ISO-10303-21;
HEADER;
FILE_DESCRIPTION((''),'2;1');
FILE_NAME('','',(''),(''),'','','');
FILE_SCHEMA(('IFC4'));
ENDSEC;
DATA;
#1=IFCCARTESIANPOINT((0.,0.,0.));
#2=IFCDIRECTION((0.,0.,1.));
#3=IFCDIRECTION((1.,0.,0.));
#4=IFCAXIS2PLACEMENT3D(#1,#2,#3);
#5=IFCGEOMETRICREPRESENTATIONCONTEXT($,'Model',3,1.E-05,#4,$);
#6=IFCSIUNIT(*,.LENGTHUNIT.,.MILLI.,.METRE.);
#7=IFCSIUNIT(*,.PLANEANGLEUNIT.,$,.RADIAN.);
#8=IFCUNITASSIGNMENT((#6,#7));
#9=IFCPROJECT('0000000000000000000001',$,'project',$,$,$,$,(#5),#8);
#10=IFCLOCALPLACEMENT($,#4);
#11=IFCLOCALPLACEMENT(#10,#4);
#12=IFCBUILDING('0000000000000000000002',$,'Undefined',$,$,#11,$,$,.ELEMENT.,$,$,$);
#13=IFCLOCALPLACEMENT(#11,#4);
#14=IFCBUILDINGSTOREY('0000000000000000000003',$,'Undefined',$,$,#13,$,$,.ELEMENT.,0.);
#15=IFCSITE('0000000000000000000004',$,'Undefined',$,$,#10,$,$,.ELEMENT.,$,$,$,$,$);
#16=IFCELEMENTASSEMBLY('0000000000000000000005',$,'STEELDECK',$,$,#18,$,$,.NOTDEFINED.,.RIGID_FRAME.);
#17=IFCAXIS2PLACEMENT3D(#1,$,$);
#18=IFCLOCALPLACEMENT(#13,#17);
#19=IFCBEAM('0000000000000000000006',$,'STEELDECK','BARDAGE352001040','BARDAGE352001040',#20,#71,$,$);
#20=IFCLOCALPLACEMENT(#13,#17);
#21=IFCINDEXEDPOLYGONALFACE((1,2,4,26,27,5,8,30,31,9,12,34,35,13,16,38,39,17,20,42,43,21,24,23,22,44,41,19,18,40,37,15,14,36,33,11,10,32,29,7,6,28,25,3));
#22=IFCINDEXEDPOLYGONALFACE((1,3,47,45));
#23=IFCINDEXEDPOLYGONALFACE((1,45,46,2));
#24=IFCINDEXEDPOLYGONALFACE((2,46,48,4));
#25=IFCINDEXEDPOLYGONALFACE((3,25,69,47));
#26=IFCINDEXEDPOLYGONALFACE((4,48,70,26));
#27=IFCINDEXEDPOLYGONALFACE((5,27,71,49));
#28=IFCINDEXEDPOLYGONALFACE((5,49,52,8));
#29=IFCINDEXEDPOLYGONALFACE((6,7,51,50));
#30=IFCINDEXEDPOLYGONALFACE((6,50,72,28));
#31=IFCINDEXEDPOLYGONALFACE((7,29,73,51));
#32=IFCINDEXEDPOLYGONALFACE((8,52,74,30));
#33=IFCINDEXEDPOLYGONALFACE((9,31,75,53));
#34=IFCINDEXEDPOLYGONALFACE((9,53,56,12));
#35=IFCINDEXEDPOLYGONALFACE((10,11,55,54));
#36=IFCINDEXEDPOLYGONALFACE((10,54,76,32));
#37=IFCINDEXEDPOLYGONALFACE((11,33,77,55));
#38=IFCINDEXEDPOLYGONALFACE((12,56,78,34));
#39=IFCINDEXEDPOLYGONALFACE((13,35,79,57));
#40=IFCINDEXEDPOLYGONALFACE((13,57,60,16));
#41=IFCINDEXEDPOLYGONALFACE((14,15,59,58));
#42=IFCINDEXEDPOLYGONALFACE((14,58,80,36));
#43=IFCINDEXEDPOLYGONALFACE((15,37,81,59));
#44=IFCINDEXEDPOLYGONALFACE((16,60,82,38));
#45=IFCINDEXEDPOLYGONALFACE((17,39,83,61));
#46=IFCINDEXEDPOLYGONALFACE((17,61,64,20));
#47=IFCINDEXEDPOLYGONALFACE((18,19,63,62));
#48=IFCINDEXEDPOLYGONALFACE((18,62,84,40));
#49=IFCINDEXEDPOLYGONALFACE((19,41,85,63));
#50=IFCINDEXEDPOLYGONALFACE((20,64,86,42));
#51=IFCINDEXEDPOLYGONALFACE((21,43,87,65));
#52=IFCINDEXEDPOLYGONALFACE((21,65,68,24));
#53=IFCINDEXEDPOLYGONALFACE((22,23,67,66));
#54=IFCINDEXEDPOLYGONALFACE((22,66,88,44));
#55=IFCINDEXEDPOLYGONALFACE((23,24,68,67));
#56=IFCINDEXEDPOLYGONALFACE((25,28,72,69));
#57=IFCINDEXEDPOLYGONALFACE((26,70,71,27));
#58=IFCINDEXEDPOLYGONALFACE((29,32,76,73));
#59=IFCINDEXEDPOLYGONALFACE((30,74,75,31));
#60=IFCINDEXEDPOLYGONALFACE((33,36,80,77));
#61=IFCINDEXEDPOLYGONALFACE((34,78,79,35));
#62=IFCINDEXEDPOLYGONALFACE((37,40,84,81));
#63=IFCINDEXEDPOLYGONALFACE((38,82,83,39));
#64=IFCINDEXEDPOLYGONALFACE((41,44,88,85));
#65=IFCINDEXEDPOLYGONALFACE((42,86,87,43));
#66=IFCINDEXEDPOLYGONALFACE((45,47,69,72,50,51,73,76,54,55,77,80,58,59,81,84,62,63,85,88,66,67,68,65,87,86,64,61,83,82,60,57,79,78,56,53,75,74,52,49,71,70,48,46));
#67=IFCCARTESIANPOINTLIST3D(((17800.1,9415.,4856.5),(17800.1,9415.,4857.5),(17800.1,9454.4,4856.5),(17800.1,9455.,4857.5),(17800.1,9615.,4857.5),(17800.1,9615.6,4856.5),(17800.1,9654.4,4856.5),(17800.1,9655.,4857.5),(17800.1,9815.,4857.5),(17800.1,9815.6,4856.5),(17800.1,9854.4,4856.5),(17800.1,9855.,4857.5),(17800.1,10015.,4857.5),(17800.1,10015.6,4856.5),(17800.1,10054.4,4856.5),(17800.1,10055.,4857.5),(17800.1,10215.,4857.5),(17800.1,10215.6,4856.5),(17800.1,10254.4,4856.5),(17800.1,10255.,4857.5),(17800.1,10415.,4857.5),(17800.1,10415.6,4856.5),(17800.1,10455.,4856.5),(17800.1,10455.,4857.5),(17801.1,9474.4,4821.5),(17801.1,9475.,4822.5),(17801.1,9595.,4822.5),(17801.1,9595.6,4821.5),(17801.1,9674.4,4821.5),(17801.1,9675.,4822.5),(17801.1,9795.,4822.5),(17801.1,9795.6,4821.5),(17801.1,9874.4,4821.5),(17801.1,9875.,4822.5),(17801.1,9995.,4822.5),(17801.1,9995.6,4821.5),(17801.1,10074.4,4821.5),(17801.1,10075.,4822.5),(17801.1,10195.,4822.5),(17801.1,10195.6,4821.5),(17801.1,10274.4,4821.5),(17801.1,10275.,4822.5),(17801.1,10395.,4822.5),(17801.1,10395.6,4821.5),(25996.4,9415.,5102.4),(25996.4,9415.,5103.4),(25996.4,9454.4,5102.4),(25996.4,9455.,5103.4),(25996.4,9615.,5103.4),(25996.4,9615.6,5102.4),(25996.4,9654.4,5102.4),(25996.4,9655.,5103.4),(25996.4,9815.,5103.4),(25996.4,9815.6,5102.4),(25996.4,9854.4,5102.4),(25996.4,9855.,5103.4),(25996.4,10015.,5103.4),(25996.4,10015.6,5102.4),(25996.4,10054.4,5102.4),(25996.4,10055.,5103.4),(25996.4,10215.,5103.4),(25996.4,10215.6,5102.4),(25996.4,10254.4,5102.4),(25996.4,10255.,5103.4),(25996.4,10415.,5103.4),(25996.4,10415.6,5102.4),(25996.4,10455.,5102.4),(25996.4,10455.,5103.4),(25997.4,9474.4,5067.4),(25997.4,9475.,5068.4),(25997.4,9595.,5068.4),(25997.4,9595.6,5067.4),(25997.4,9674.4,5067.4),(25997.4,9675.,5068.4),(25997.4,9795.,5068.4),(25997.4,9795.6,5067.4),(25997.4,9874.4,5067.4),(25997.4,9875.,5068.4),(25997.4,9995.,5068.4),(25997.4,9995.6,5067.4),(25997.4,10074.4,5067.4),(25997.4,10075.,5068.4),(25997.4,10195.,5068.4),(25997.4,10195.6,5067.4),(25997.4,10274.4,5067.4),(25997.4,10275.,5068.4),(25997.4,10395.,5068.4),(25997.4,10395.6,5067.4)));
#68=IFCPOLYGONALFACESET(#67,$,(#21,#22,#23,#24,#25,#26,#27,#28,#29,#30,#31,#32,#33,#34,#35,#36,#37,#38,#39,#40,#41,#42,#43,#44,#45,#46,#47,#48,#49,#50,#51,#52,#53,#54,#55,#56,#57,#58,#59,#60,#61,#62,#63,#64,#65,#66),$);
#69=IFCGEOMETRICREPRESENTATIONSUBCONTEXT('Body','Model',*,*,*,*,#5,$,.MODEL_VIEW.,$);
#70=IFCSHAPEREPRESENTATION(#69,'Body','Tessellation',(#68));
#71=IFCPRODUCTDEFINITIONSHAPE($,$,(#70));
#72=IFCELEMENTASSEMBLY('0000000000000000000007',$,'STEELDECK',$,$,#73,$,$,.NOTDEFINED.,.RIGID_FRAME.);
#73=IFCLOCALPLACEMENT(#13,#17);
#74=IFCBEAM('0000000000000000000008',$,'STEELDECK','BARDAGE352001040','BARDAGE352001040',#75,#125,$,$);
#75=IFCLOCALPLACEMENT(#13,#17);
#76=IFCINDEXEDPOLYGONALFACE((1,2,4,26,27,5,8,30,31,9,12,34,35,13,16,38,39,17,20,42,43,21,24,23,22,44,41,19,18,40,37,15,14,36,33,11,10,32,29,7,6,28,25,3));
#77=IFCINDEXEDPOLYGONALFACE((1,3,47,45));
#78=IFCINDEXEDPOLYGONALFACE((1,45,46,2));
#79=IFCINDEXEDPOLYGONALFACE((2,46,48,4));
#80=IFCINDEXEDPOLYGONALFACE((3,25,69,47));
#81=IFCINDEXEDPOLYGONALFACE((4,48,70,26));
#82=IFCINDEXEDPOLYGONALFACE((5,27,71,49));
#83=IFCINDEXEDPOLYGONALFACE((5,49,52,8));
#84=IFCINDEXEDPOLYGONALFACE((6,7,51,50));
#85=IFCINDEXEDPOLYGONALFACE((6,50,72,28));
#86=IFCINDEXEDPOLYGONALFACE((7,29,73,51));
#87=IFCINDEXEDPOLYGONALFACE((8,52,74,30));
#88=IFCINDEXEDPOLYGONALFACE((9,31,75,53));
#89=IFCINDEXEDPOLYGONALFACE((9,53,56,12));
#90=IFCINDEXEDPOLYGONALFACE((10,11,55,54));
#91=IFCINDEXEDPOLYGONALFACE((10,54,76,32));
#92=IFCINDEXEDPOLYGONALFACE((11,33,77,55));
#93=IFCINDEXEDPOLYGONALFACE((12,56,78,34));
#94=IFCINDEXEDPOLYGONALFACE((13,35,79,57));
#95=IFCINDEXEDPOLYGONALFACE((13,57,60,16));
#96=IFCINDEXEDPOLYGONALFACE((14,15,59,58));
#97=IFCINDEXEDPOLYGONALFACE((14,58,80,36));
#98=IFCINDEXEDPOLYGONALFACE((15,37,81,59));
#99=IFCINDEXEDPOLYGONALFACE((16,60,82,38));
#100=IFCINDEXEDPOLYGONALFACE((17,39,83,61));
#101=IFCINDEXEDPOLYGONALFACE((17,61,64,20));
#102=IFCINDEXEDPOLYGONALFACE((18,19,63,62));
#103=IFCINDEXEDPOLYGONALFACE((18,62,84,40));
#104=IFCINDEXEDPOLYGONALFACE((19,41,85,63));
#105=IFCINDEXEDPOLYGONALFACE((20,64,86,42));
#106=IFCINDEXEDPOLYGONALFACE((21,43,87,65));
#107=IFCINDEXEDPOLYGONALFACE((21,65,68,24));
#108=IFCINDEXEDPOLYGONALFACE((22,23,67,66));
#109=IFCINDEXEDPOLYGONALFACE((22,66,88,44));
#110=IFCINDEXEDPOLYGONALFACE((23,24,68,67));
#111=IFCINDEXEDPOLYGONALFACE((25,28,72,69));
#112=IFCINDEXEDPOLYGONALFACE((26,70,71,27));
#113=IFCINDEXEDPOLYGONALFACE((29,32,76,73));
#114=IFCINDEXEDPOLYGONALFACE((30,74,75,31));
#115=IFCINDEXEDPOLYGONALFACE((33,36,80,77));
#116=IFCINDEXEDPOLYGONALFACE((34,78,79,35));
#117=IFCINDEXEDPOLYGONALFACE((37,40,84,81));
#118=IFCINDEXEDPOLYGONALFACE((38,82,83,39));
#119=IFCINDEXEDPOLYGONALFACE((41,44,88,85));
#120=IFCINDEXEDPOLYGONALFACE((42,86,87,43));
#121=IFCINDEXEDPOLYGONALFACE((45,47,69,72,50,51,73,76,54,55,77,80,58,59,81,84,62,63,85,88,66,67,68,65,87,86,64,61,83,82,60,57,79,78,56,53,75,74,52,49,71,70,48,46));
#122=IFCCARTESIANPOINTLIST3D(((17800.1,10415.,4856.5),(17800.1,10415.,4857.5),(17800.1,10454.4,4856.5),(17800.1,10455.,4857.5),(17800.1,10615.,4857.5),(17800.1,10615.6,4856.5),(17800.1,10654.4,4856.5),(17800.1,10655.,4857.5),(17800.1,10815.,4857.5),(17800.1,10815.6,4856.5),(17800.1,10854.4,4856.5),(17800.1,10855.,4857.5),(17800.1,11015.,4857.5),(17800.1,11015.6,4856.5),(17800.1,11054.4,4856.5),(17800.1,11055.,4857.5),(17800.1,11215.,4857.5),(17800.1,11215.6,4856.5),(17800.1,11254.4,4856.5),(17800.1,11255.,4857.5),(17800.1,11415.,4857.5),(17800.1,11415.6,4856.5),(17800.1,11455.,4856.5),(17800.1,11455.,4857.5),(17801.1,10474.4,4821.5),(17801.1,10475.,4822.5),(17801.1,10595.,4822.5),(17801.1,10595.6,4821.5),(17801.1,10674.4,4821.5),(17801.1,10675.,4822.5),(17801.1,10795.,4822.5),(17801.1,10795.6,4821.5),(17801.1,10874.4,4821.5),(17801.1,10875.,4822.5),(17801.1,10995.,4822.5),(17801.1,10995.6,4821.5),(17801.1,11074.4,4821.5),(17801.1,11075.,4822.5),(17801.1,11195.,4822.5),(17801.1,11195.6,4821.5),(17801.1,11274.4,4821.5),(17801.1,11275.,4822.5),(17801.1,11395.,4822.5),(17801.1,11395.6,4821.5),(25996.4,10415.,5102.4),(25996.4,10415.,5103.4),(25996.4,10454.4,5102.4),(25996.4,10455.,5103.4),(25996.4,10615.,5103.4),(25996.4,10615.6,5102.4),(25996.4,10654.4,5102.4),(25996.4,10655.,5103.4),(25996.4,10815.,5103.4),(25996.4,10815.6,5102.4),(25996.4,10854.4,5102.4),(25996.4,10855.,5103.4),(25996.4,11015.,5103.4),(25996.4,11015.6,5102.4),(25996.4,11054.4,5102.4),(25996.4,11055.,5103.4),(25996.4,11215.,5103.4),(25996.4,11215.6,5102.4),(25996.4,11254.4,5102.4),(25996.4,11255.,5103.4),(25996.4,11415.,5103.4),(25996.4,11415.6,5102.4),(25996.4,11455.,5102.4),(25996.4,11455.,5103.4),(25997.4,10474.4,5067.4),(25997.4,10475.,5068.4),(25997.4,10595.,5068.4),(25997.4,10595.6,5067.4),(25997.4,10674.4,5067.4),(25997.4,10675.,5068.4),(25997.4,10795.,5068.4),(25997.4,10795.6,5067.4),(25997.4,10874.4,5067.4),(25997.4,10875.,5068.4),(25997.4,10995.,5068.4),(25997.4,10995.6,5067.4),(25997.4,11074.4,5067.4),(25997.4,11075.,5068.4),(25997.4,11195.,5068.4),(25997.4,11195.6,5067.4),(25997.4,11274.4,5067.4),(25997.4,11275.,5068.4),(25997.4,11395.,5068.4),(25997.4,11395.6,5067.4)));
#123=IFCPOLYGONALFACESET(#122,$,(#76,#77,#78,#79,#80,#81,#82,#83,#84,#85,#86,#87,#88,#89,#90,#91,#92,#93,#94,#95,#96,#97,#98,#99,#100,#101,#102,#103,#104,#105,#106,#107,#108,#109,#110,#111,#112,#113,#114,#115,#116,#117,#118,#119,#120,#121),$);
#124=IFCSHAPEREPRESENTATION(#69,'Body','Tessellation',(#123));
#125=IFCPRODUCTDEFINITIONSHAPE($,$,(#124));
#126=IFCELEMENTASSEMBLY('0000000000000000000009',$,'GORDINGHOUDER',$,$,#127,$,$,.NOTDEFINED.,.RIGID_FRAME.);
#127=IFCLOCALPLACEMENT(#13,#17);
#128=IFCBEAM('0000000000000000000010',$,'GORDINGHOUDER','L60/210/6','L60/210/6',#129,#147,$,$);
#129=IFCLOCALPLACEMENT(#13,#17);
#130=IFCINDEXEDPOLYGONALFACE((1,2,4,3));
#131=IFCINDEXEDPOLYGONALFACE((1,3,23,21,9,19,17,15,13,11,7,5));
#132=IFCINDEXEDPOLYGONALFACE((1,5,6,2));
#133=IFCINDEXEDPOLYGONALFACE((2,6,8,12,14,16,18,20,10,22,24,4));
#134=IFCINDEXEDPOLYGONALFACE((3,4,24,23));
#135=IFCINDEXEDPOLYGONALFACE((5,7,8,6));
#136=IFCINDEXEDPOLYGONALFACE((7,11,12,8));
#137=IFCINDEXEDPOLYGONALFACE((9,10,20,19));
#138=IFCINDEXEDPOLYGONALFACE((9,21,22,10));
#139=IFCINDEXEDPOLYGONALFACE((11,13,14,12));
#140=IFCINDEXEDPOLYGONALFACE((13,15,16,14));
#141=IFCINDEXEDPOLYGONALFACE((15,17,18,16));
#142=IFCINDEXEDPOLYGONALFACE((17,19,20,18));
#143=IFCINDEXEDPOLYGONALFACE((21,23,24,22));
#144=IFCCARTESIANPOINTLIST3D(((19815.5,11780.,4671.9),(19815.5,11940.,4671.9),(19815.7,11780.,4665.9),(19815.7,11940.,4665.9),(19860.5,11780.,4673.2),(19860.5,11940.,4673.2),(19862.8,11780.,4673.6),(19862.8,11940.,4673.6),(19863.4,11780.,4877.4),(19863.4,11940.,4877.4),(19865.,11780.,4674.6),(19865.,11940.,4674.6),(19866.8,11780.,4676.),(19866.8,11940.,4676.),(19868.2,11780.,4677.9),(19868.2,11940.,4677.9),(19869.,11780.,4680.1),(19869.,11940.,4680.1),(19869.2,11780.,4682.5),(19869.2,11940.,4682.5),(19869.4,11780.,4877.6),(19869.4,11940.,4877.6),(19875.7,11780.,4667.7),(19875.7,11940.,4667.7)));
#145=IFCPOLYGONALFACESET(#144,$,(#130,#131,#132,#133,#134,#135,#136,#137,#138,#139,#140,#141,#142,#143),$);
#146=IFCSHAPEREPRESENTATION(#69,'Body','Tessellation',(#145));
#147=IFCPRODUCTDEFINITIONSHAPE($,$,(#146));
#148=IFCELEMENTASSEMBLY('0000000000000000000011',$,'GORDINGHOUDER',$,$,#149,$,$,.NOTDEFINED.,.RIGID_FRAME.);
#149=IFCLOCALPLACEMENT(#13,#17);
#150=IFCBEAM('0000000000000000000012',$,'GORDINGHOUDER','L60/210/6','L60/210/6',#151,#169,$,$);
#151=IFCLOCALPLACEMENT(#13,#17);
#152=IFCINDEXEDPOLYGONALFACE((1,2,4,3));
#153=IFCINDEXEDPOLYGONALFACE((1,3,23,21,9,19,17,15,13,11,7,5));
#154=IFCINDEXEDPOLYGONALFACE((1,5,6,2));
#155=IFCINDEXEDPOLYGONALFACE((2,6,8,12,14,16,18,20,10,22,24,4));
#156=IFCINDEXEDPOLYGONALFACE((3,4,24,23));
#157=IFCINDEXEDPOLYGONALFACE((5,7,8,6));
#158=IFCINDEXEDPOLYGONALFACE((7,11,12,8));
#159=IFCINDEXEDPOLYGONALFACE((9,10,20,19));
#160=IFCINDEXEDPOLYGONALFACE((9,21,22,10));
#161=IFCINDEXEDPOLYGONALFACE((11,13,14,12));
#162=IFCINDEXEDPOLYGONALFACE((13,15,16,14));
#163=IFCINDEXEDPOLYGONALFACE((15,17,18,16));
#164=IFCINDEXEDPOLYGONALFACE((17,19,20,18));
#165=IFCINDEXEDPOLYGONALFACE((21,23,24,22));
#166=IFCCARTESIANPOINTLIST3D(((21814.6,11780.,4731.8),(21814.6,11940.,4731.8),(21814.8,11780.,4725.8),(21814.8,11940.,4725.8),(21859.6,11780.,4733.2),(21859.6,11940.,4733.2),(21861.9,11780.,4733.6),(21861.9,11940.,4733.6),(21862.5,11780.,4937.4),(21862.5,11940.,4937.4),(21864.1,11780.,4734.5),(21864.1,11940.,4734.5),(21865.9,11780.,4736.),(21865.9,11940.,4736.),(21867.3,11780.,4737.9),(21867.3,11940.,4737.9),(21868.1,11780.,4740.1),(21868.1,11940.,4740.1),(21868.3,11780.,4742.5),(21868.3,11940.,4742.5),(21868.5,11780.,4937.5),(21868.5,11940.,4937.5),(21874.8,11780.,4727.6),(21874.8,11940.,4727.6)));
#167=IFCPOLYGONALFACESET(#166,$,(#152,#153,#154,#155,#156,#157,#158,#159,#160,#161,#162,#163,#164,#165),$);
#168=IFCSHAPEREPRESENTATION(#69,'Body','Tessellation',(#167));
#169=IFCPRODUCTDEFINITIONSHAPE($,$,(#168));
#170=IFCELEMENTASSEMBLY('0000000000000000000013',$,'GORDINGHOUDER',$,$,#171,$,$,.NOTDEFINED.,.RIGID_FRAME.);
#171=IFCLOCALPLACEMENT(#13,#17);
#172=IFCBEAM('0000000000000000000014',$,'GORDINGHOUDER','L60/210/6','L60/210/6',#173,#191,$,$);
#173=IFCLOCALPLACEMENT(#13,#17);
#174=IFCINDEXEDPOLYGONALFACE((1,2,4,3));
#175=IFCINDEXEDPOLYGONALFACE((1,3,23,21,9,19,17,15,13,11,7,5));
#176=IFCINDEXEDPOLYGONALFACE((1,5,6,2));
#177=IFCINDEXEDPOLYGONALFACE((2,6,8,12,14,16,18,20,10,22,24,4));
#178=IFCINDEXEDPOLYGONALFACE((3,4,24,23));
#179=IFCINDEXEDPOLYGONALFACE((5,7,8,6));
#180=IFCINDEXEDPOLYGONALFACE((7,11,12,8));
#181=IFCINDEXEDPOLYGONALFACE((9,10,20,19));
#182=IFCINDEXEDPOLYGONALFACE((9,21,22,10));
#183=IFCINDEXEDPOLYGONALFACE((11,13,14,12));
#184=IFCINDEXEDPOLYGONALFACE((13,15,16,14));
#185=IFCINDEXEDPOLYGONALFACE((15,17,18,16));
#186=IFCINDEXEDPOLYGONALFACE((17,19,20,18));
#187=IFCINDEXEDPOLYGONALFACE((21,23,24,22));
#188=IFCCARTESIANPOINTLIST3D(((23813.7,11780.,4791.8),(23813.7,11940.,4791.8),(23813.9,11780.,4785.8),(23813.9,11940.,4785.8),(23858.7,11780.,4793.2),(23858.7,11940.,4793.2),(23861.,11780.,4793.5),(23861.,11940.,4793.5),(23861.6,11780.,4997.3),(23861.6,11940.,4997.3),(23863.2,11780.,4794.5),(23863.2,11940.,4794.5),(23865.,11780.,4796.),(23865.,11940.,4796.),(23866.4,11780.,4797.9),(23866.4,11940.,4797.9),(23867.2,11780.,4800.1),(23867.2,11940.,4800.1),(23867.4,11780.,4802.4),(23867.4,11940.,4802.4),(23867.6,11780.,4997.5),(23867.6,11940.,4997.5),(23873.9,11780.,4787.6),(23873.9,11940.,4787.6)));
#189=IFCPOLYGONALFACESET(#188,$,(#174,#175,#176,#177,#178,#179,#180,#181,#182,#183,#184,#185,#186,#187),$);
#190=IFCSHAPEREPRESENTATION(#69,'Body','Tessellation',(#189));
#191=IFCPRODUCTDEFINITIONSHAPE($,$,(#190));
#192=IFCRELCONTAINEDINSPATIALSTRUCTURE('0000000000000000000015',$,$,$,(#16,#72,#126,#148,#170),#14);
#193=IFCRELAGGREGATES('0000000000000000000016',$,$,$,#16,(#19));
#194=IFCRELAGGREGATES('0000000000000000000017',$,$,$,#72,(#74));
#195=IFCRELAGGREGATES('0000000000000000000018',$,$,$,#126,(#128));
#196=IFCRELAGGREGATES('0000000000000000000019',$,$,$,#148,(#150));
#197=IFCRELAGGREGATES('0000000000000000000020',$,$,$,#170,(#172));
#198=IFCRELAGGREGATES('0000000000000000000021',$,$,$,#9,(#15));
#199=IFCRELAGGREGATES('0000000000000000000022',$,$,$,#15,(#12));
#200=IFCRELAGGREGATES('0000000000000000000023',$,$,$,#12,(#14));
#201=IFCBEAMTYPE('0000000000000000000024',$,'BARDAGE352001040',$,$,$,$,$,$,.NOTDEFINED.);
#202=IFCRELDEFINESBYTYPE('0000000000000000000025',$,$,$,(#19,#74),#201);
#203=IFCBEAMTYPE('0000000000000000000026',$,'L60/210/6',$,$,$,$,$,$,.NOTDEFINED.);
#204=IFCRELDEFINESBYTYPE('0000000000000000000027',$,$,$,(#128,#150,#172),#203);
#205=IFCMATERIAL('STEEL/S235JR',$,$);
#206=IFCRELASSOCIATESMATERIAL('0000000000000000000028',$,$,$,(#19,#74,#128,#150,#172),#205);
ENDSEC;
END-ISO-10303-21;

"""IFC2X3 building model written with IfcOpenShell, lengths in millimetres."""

from ifc_helpers import new_model, si_unit, frame, frame_2d, origin_with_axes, place, context, subcontext, project, spatial, polyline, l_section, outline, extrude, material, type_object, element, aggregate, save


model = new_model("IFC2X3")

# Units and contexts
model_context = context("Model", 3, precision=1e-05, world=origin_with_axes())
body_context = subcontext(model_context, "Body", "Model", "MODEL_VIEW")
ifc_project = project(units=[si_unit("LENGTHUNIT", "METRE", prefix="MILLI"), si_unit("PLANEANGLEUNIT", "RADIAN")], contexts=[model_context])

# Site, building, storey
site_placement = place(None, origin_with_axes())
site = spatial("IfcSite", under=ifc_project, at=site_placement, Name="Undefined", CompositionType="ELEMENT")
building_placement = place(site_placement, origin_with_axes())
building = spatial("IfcBuilding", under=site, at=building_placement, Name="Undefined", CompositionType="ELEMENT")
storey_placement = place(building_placement, origin_with_axes())
storey = spatial("IfcBuildingStorey", under=building, at=storey_placement, Name="Undefined", CompositionType="ELEMENT", Elevation=0.0)

# Element assemblies, beams
ifc_material_1 = material(Name="STEEL/S235JR")
beam_type_1 = type_object("IfcBeamType", Name="BARDAGE352001040", PredefinedType="NOTDEFINED")
assembly_1_placement = place(storey_placement, origin_with_axes())
assembly_1 = element("IfcElementAssembly", 1, at=assembly_1_placement, inside=storey, Name="STEELDECK", AssemblyPlace="NOTDEFINED", PredefinedType="RIGID_FRAME")
beam_1_placement = place(assembly_1_placement, frame((17800.1, 10455.0, 4857.5), z_axis=(-0.029987, 0.0, 0.99955), x_axis=(0.99955, 0.0, 0.029986)))
beam_1 = element("IfcBeam", 2, at=beam_1_placement, type_object=beam_type_1, material=ifc_material_1, Name="STEELDECK", Description="BARDAGE352001040", ObjectType="BARDAGE352001040", context=body_context, shape_type="SweptSolid", body=[
    extrude(outline(polyline([(200.6, -1.0), (180.6, -36.0), (59.4, -36.0), (39.4, -1.0), (0.0, -1.0), (0.0, 0.0), (40.0, 0.0), (60.0, -35.0), (180.0, -35.0), (200.0, 0.0), (240.0, 0.0), (260.0, -35.0), (380.0, -35.0), (400.0, 0.0), (440.0, 0.0), (460.0, -35.0), (580.0, -35.0), (600.0, 0.0), (640.0, 0.0), (660.0, -35.0), (780.0, -35.0), (800.0, 0.0), (840.0, 0.0), (860.0, -35.0), (980.0, -35.0), (1000.0, 0.0), (1040.0, 0.0), (1040.0, -1.0), (1000.6, -1.0), (980.6, -36.0), (859.4, -36.0), (839.4, -1.0), (800.6, -1.0), (780.6, -36.0), (659.4, -36.0), (639.4, -1.0), (600.6, -1.0), (580.6, -36.0), (459.4, -36.0), (439.4, -1.0), (400.6, -1.0), (380.6, -36.0), (259.4, -36.0), (239.4, -1.0), (200.6, -1.0)])), frame((8200.0, 0.0, 0.0), z_axis=(-1.0, 0.0, 0.0), x_axis=(0.0, -1.0, 0.0)), (0.0, 0.0, 1.0), 8200.0),
])
aggregate(assembly_1, [beam_1])
assembly_2_placement = place(storey_placement, origin_with_axes())
assembly_2 = element("IfcElementAssembly", 3, at=assembly_2_placement, inside=storey, Name="STEELDECK", AssemblyPlace="NOTDEFINED", PredefinedType="RIGID_FRAME")
beam_2_placement = place(assembly_2_placement, frame((17800.1, 11455.0, 4857.5), z_axis=(-0.029987, 0.0, 0.99955), x_axis=(0.99955, 0.0, 0.029986)))
beam_2 = element("IfcBeam", 4, at=beam_2_placement, type_object=beam_type_1, material=ifc_material_1, Name="STEELDECK", Description="BARDAGE352001040", ObjectType="BARDAGE352001040", context=body_context, shape_type="SweptSolid", body=[
    extrude(outline(polyline([(200.6, -1.0), (180.6, -36.0), (59.4, -36.0), (39.4, -1.0), (0.0, -1.0), (0.0, 0.0), (40.0, 0.0), (60.0, -35.0), (180.0, -35.0), (200.0, 0.0), (240.0, 0.0), (260.0, -35.0), (380.0, -35.0), (400.0, 0.0), (440.0, 0.0), (460.0, -35.0), (580.0, -35.0), (600.0, 0.0), (640.0, 0.0), (660.0, -35.0), (780.0, -35.0), (800.0, 0.0), (840.0, 0.0), (860.0, -35.0), (980.0, -35.0), (1000.0, 0.0), (1040.0, 0.0), (1040.0, -1.0), (1000.6, -1.0), (980.6, -36.0), (859.4, -36.0), (839.4, -1.0), (800.6, -1.0), (780.6, -36.0), (659.4, -36.0), (639.4, -1.0), (600.6, -1.0), (580.6, -36.0), (459.4, -36.0), (439.4, -1.0), (400.6, -1.0), (380.6, -36.0), (259.4, -36.0), (239.4, -1.0), (200.6, -1.0)])), frame((8200.0, 0.0, 0.0), z_axis=(-1.0, 0.0, 0.0), x_axis=(0.0, -1.0, 0.0)), (0.0, 0.0, 1.0), 8200.0),
])
aggregate(assembly_2, [beam_2])
assembly_3_placement = place(storey_placement, origin_with_axes())
assembly_3 = element("IfcElementAssembly", 5, at=assembly_3_placement, inside=storey, Name="GORDINGHOUDER", AssemblyPlace="NOTDEFINED", PredefinedType="RIGID_FRAME")
beam_type_2 = type_object("IfcBeamType", Name="L60/210/6", PredefinedType="NOTDEFINED")
beam_3_placement = place(assembly_3_placement, frame((19842.5, 11780.0, 4771.7), z_axis=(-0.99955, 0.0, -0.029987), x_axis=(0.0, 1.0, 0.0)))
beam_3 = element("IfcBeam", 6, at=beam_3_placement, type_object=beam_type_2, material=ifc_material_1, Name="GORDINGHOUDER", Description="L60/210/6", ObjectType="L60/210/6", context=body_context, shape_type="SweptSolid", body=[
    extrude(l_section(Depth=60.0, Width=210.0, Thickness=6.0, FilletRadius=9.0, at=frame_2d((0.0, 0.0), x_axis=(1.0, 0.0))), frame((160.0, 0.0, 0.0), z_axis=(-1.0, 0.0, 0.0), x_axis=(0.0, -1.0, 0.0)), (0.0, 0.0, 1.0), 160.0),
])
aggregate(assembly_3, [beam_3])
assembly_4_placement = place(storey_placement, origin_with_axes())
assembly_4 = element("IfcElementAssembly", 7, at=assembly_4_placement, inside=storey, Name="GORDINGHOUDER", AssemblyPlace="NOTDEFINED", PredefinedType="RIGID_FRAME")
beam_4_placement = place(assembly_4_placement, frame((21841.6, 11780.0, 4831.7), z_axis=(-0.99955, 0.0, -0.029987), x_axis=(0.0, 1.0, 0.0)))
beam_4 = element("IfcBeam", 8, at=beam_4_placement, type_object=beam_type_2, material=ifc_material_1, Name="GORDINGHOUDER", Description="L60/210/6", ObjectType="L60/210/6", context=body_context, shape_type="SweptSolid", body=[
    extrude(l_section(Depth=60.0, Width=210.0, Thickness=6.0, FilletRadius=9.0, at=frame_2d((0.0, 0.0), x_axis=(1.0, 0.0))), frame((160.0, 0.0, 0.0), z_axis=(-1.0, 0.0, 0.0), x_axis=(0.0, -1.0, 0.0)), (0.0, 0.0, 1.0), 160.0),
])
aggregate(assembly_4, [beam_4])
assembly_5_placement = place(storey_placement, origin_with_axes())
assembly_5 = element("IfcElementAssembly", 9, at=assembly_5_placement, inside=storey, Name="GORDINGHOUDER", AssemblyPlace="NOTDEFINED", PredefinedType="RIGID_FRAME")
beam_5_placement = place(assembly_5_placement, frame((23840.7, 11780.0, 4891.7), z_axis=(-0.99955, 0.0, -0.029987), x_axis=(0.0, 1.0, 0.0)))
beam_5 = element("IfcBeam", 10, at=beam_5_placement, type_object=beam_type_2, material=ifc_material_1, Name="GORDINGHOUDER", Description="L60/210/6", ObjectType="L60/210/6", context=body_context, shape_type="SweptSolid", body=[
    extrude(l_section(Depth=60.0, Width=210.0, Thickness=6.0, FilletRadius=9.0, at=frame_2d((0.0, 0.0), x_axis=(1.0, 0.0))), frame((160.0, 0.0, 0.0), z_axis=(-1.0, 0.0, 0.0), x_axis=(0.0, -1.0, 0.0)), (0.0, 0.0, 1.0), 160.0),
])
aggregate(assembly_5, [beam_5])

save(model, "model.ifc")
